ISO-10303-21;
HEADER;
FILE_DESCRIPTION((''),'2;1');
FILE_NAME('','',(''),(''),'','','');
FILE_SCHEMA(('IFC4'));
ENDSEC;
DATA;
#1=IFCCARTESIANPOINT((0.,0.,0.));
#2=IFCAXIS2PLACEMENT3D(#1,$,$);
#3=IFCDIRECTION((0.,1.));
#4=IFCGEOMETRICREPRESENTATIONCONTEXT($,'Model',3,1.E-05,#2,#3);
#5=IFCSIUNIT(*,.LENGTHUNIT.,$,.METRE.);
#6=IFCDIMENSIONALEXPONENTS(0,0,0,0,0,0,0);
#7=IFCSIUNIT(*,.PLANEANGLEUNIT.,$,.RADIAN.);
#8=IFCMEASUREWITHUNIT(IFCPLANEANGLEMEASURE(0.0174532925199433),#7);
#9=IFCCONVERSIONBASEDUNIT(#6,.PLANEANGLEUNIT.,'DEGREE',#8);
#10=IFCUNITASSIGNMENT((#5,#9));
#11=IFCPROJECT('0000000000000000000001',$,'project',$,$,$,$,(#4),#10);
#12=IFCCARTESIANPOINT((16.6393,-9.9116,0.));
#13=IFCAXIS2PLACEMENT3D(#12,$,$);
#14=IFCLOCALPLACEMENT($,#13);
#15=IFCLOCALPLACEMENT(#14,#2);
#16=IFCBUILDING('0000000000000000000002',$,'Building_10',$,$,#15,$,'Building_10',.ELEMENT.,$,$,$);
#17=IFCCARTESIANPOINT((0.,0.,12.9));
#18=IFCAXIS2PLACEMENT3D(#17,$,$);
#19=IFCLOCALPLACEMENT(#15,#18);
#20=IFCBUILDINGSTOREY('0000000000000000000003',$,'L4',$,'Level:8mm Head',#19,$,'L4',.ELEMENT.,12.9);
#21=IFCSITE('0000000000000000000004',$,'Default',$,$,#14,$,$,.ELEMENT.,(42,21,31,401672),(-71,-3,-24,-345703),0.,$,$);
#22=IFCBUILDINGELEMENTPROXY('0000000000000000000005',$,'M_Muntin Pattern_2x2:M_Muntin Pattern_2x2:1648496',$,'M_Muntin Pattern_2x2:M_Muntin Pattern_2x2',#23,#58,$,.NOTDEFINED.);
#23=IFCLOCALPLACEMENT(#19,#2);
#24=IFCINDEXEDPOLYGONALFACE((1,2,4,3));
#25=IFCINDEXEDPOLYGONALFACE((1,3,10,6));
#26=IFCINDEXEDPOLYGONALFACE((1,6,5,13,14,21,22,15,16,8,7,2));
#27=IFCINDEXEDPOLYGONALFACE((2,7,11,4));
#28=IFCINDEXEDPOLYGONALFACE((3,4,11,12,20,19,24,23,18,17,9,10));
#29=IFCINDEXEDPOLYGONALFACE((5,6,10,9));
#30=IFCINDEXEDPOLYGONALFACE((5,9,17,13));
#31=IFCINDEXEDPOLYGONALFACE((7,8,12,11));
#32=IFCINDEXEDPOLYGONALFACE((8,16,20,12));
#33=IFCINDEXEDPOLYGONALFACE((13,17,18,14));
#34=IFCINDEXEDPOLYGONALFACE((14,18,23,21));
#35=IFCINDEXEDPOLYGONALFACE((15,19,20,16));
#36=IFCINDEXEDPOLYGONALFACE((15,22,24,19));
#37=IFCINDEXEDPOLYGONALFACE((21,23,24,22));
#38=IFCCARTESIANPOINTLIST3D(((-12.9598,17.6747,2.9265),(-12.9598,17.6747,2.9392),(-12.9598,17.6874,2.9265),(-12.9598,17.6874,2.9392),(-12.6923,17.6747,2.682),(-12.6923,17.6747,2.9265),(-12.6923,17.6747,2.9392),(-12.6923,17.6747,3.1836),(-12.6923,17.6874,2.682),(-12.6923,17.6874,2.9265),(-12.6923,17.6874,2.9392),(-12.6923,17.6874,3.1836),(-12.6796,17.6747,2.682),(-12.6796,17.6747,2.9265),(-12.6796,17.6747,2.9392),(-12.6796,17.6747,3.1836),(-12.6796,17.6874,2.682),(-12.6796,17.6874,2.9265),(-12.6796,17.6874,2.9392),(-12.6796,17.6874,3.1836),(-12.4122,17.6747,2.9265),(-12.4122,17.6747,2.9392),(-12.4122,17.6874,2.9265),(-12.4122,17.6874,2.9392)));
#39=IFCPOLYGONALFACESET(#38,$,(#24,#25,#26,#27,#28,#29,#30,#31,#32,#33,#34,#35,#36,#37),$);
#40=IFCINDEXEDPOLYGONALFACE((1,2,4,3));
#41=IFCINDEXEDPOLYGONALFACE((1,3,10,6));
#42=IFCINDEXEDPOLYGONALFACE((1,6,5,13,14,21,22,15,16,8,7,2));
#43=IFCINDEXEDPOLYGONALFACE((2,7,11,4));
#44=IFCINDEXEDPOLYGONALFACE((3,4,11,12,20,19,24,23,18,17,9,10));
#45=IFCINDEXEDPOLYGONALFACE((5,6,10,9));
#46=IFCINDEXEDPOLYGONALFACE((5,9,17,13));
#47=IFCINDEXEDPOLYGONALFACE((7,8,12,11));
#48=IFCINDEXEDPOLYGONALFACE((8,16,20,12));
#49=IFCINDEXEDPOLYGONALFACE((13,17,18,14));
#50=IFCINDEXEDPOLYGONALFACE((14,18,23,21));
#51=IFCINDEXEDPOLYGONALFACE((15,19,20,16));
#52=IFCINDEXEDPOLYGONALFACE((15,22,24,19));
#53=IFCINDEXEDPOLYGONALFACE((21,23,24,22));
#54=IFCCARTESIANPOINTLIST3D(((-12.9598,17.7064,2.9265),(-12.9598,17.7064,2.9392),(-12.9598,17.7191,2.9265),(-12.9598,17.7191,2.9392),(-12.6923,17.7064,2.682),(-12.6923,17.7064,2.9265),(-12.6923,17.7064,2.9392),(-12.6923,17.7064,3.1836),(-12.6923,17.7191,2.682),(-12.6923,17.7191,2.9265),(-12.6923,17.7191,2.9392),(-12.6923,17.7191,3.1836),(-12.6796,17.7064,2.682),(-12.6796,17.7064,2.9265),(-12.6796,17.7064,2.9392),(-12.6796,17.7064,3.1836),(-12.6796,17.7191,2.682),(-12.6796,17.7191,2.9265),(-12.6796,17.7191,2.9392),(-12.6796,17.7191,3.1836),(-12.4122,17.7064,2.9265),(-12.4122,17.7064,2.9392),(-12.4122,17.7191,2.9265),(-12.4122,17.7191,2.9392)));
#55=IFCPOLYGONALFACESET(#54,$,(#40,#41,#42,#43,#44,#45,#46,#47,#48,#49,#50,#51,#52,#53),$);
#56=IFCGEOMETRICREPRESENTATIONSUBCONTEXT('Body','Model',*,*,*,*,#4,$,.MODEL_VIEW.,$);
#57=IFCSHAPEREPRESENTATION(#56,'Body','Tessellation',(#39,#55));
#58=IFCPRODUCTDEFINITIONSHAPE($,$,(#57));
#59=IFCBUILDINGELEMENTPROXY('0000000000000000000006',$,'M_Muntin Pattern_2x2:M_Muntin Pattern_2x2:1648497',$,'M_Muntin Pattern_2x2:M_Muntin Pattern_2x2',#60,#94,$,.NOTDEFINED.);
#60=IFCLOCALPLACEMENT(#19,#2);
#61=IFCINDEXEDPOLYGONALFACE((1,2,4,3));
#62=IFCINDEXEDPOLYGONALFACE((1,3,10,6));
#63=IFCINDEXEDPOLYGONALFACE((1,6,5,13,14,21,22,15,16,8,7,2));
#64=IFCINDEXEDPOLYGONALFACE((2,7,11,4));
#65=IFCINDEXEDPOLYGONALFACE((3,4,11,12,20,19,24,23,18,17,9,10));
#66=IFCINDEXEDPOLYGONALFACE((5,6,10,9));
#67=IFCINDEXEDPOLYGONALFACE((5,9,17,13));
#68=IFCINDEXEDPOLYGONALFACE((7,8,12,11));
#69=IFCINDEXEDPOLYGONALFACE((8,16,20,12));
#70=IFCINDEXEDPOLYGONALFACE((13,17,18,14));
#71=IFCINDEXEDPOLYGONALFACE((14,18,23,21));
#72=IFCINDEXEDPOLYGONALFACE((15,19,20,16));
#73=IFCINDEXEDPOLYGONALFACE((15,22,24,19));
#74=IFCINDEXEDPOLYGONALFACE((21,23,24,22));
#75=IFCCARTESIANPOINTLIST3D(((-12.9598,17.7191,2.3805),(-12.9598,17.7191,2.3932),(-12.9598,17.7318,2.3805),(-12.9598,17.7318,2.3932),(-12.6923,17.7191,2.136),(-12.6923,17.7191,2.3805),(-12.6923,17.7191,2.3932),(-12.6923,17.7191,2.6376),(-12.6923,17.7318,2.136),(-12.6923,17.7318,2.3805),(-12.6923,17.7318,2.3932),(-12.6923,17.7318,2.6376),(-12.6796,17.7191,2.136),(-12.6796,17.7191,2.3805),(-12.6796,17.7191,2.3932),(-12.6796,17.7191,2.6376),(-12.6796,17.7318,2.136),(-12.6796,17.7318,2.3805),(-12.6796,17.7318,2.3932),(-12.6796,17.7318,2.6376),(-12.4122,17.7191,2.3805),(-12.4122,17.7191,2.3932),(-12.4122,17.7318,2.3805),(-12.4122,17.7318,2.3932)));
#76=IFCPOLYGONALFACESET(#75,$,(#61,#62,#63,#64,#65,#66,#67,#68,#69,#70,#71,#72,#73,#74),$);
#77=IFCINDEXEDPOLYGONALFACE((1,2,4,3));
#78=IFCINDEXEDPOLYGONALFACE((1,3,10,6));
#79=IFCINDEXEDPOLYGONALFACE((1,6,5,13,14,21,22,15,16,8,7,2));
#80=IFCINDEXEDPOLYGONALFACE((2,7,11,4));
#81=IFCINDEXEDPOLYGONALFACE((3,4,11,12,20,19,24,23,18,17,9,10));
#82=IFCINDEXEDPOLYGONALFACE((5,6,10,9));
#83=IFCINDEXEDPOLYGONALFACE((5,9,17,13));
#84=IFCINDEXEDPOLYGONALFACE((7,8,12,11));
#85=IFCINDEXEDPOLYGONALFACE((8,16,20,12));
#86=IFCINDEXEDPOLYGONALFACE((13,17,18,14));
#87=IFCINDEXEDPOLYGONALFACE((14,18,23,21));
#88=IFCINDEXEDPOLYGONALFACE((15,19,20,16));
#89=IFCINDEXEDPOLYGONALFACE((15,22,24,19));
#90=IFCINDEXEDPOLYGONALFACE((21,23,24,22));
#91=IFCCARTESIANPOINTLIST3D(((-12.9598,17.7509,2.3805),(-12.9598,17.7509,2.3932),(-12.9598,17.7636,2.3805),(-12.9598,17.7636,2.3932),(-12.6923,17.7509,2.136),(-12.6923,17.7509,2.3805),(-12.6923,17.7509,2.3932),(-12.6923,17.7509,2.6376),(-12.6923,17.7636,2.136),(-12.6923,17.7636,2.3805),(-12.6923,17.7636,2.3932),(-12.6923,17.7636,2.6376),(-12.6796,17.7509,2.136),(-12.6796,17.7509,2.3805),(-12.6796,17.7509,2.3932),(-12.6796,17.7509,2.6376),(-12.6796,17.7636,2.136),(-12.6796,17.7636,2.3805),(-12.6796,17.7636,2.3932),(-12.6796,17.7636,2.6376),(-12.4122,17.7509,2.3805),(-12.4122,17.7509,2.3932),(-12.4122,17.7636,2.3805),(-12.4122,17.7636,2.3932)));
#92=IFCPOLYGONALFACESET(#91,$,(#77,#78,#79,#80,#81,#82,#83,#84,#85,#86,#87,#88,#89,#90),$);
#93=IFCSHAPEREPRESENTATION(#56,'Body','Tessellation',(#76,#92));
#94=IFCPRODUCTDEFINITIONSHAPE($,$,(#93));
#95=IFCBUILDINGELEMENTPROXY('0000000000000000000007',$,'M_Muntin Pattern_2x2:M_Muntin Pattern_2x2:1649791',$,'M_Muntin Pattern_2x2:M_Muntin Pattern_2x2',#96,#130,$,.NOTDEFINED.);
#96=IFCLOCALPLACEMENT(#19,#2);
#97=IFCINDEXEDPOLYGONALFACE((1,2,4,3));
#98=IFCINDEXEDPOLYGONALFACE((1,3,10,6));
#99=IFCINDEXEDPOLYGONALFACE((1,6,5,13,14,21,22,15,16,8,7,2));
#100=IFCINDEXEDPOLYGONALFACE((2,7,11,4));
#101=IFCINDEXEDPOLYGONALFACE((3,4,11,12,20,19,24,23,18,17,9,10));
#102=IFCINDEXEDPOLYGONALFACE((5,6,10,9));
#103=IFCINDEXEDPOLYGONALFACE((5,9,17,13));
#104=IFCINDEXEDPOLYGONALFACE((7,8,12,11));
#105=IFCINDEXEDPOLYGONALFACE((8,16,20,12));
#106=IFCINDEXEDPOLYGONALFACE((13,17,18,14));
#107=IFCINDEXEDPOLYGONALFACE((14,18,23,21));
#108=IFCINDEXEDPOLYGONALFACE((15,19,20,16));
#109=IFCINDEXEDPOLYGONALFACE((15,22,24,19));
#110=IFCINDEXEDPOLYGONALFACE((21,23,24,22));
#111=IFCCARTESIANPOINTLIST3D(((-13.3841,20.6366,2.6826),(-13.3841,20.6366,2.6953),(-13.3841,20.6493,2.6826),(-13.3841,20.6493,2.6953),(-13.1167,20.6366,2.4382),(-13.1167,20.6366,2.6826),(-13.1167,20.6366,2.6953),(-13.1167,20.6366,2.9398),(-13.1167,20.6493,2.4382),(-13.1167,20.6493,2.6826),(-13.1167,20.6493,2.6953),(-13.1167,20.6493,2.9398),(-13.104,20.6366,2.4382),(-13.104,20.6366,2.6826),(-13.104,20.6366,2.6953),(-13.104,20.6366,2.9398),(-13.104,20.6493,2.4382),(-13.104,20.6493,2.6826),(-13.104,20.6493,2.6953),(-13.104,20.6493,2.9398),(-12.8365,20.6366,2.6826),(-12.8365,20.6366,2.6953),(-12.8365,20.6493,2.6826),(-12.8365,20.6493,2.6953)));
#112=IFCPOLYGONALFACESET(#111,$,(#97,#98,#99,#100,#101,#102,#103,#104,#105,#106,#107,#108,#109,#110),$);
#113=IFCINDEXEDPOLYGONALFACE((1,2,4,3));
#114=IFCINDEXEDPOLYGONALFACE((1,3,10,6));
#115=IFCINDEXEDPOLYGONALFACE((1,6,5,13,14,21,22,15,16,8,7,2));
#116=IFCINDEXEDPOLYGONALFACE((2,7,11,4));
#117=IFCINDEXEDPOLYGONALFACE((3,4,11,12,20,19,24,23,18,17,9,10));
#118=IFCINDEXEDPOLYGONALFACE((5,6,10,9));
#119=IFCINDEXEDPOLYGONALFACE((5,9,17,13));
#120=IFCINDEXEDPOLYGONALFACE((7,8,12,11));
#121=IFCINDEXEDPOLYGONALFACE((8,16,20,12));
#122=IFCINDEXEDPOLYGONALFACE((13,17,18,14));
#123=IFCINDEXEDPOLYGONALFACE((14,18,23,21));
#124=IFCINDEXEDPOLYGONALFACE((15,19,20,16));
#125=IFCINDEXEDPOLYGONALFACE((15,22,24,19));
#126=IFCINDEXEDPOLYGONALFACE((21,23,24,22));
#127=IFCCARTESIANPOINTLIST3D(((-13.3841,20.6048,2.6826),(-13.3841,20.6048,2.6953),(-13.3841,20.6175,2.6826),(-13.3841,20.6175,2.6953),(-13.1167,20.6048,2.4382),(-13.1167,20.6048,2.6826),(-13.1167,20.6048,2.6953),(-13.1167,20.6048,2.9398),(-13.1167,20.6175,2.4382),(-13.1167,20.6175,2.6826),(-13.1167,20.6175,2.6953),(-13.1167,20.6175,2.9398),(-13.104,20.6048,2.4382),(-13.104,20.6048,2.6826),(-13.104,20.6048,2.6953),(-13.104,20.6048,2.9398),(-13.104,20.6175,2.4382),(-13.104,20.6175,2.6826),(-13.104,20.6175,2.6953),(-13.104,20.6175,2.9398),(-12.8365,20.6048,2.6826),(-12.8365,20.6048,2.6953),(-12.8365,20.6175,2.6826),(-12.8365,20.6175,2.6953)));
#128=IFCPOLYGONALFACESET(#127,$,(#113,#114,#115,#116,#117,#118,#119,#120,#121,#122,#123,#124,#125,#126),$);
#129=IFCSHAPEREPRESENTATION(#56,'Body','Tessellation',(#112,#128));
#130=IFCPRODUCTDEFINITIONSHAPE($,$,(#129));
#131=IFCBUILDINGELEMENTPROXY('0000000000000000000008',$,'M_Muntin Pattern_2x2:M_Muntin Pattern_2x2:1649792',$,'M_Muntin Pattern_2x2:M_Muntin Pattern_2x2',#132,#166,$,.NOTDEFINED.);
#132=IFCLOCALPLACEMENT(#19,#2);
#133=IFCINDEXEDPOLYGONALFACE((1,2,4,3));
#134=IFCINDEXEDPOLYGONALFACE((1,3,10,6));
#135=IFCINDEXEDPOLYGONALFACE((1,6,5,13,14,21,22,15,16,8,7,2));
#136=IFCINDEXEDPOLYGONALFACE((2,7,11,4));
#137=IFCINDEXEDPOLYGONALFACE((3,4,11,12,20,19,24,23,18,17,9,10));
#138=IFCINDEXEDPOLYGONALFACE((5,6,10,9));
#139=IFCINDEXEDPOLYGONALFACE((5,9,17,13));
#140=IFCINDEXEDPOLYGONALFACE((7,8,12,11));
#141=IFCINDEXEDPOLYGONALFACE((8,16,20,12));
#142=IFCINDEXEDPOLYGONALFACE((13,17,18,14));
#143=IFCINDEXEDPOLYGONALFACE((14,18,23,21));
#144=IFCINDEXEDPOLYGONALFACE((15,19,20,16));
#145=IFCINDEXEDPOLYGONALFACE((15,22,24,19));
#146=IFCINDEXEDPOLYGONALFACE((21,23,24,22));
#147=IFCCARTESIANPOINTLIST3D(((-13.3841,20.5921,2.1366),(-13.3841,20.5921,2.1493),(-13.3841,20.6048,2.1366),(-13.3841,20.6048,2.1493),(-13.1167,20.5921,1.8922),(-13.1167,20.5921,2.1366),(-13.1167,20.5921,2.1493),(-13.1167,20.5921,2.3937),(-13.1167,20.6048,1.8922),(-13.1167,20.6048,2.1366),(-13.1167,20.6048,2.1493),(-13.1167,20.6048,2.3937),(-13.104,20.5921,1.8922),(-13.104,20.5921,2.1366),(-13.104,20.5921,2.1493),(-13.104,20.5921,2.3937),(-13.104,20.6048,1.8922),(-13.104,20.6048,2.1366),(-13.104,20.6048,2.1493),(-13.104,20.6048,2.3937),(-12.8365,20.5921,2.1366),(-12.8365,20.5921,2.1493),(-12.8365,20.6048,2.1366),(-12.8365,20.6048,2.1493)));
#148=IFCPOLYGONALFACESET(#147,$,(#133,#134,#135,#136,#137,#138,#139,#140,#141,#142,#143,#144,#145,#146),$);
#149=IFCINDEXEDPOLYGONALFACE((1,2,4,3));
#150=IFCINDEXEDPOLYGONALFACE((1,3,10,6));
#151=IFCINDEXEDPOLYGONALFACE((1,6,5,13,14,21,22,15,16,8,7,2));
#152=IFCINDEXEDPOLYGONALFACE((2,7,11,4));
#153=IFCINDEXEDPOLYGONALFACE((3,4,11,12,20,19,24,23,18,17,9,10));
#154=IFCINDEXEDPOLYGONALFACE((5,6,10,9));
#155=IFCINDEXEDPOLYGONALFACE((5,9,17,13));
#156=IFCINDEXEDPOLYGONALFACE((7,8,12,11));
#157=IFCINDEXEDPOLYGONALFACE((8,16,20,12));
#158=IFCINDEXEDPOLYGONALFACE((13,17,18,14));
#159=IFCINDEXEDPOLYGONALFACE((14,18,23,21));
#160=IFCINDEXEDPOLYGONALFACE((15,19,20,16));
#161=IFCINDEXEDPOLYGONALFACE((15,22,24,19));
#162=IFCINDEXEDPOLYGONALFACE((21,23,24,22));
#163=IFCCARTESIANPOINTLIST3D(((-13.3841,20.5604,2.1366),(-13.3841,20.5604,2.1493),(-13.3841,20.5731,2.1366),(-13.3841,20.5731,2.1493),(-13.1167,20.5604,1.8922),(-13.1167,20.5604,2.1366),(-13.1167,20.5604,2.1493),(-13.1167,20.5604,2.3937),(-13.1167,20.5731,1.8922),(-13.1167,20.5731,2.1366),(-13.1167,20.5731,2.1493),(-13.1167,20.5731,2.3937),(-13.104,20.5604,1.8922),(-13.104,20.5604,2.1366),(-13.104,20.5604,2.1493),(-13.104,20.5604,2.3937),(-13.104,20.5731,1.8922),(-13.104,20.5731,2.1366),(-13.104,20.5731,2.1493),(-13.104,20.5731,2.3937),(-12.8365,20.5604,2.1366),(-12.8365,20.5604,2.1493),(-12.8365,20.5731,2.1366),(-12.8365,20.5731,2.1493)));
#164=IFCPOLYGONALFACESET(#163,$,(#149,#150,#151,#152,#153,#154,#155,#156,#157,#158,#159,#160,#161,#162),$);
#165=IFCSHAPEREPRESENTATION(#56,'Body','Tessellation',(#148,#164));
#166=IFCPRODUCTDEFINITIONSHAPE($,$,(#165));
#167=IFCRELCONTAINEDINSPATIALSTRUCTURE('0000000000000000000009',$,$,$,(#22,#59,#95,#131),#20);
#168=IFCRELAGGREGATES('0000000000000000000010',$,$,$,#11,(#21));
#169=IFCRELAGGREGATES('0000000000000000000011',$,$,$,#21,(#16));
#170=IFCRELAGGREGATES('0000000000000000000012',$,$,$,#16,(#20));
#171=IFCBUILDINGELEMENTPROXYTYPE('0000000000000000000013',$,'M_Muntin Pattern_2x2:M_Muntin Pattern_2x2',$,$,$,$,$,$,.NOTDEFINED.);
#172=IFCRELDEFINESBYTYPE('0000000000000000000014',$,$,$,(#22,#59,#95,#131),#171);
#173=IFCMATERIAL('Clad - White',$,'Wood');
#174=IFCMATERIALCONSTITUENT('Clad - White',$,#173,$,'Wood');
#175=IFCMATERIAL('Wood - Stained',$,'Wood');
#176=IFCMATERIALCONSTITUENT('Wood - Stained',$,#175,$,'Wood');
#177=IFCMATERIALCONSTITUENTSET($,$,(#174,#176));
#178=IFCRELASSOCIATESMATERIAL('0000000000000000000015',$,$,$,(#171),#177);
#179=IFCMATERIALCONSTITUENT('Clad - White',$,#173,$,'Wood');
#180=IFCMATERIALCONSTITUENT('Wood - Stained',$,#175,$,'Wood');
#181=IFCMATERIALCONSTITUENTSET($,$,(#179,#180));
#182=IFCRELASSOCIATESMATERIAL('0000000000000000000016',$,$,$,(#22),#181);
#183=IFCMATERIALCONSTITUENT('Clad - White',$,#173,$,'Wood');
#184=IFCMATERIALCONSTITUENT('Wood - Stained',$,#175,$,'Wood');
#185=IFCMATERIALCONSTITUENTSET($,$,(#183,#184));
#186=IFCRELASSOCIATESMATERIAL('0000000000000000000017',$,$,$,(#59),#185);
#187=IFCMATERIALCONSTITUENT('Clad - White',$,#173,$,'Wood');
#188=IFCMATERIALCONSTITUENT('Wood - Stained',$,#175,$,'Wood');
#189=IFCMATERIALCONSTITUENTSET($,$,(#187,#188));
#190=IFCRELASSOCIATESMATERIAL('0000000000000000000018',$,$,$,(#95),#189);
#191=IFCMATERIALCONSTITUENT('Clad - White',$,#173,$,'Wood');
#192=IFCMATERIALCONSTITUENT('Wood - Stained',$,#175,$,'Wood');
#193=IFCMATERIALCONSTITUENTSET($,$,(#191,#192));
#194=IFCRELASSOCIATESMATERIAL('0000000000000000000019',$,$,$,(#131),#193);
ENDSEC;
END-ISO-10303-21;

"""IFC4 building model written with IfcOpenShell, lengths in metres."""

from ifc_helpers import new_model, entity, si_unit, converted_unit, direction, frame, origin, place, context, subcontext, project, spatial, indexed_curve, outline, extrude, source, transform, mapped, material, constituent, constituent_set, type_object, type_shapes, element, save


model = new_model("IFC4")

# Units and contexts
model_context = context("Model", 3, precision=1e-05, world=origin(), true_north=direction((0.0, 1.0)))
body_context = subcontext(model_context, "Body", "Model", "MODEL_VIEW")
ifc_project = project(units=[si_unit("LENGTHUNIT", "METRE"), converted_unit("PLANEANGLEUNIT", "DEGREE", entity("IfcPlaneAngleMeasure", 0.0174532925199433), si_unit("PLANEANGLEUNIT", "RADIAN"), dimensions=[0, 0, 0, 0, 0, 0, 0])], contexts=[model_context])

# Site, building, storey
site_placement = place(None, frame((16.6393, -9.9116, 0.0)))
site = spatial("IfcSite", under=ifc_project, at=site_placement, Name="Default", CompositionType="ELEMENT", RefLatitude=(42, 21, 31, 401672), RefLongitude=(-71, -3, -24, -345703), RefElevation=0.0)
building_placement = place(site_placement, origin())
building = spatial("IfcBuilding", under=site, at=building_placement, Name="Building_10", LongName="Building_10", CompositionType="ELEMENT")
storey_placement = place(building_placement, frame((0.0, 0.0, 12.9)))
storey = spatial("IfcBuildingStorey", under=building, at=storey_placement, Name="L4", ObjectType="Level:8mm Head", LongName="L4", CompositionType="ELEMENT", Elevation=12.9)

# Building element proxies
ifc_material_1 = material(Name="Clad - White", Category="Wood")
ifc_material_2 = material(Name="Wood - Stained", Category="Wood")
ifc_constituent_1 = constituent(ifc_material_1, Name="Clad - White", Category="Wood")
ifc_constituent_2 = constituent(ifc_material_2, Name="Wood - Stained", Category="Wood")
ifc_constituent_set_1 = constituent_set(constituents=[ifc_constituent_1, ifc_constituent_2])
ifc_constituent_3 = constituent(ifc_material_1, Name="Clad - White", Category="Wood")
ifc_constituent_4 = constituent(ifc_material_2, Name="Wood - Stained", Category="Wood")
ifc_constituent_set_2 = constituent_set(constituents=[ifc_constituent_3, ifc_constituent_4])
building_element_proxy_type_1 = type_object("IfcBuildingElementProxyType", Name="M_Muntin Pattern_2x2:M_Muntin Pattern_2x2", PredefinedType="NOTDEFINED", material=ifc_constituent_set_2)
shared_shape_1 = source(origin(), body_context, "Body", "SweptSolid", [
    extrude(outline(indexed_curve([(0.0064, -0.0064), (0.2508, -0.0064), (0.2508, 0.0063), (0.0064, 0.0063), (0.0064, 0.2738), (-0.0063, 0.2738), (-0.0063, 0.0063), (-0.2508, 0.0063), (-0.2508, -0.0064), (-0.0063, -0.0064), (-0.0063, -0.2738), (0.0064, -0.2738), (0.0064, -0.0064)], self_intersect=False)), frame((0.0, 0.0095, 0.2508), z_axis=(0.0, 1.0, 0.0), x_axis=(0.0, 0.0, 1.0)), (0.0, 0.0, 1.0), 0.0127),
    extrude(outline(indexed_curve([(0.0064, -0.0064), (0.2508, -0.0064), (0.2508, 0.0063), (0.0064, 0.0063), (0.0064, 0.2738), (-0.0063, 0.2738), (-0.0063, 0.0063), (-0.2508, 0.0063), (-0.2508, -0.0064), (-0.0063, -0.0064), (-0.0063, -0.2738), (0.0064, -0.2738), (0.0064, -0.0064)], self_intersect=False)), frame((0.0, -0.0222, 0.2508), z_axis=(0.0, 1.0, 0.0), x_axis=(0.0, 0.0, 1.0)), (0.0, 0.0, 1.0), 0.0127),
])
type_shapes(building_element_proxy_type_1, [shared_shape_1])
proxy_1_placement = place(storey_placement, frame((-12.686, 17.6969, 2.682), z_axis=(0.0, 0.0, 1.0), x_axis=(-1.0, 0.0, 0.0)))
element("IfcBuildingElementProxy", 1, at=proxy_1_placement, inside=storey, type_object=building_element_proxy_type_1, material=ifc_constituent_set_1, Name="M_Muntin Pattern_2x2:M_Muntin Pattern_2x2:1648496", ObjectType="M_Muntin Pattern_2x2:M_Muntin Pattern_2x2", PredefinedType="NOTDEFINED", context=body_context, shape_type="MappedRepresentation", body=[
    mapped(shared_shape_1, transform((0.0, 0.0, 0.0), scale=1.0)),
])
ifc_constituent_5 = constituent(ifc_material_1, Name="Clad - White", Category="Wood")
ifc_constituent_6 = constituent(ifc_material_2, Name="Wood - Stained", Category="Wood")
ifc_constituent_set_3 = constituent_set(constituents=[ifc_constituent_5, ifc_constituent_6])
proxy_2_placement = place(storey_placement, frame((-12.686, 17.7413, 2.136), z_axis=(0.0, 0.0, 1.0), x_axis=(-1.0, 0.0, 0.0)))
element("IfcBuildingElementProxy", 2, at=proxy_2_placement, inside=storey, type_object=building_element_proxy_type_1, material=ifc_constituent_set_3, Name="M_Muntin Pattern_2x2:M_Muntin Pattern_2x2:1648497", ObjectType="M_Muntin Pattern_2x2:M_Muntin Pattern_2x2", PredefinedType="NOTDEFINED", context=body_context, shape_type="MappedRepresentation", body=[
    mapped(shared_shape_1, transform((0.0, 0.0, 0.0), scale=1.0)),
])
ifc_constituent_7 = constituent(ifc_material_1, Name="Clad - White", Category="Wood")
ifc_constituent_8 = constituent(ifc_material_2, Name="Wood - Stained", Category="Wood")
ifc_constituent_set_4 = constituent_set(constituents=[ifc_constituent_7, ifc_constituent_8])
proxy_3_placement = place(storey_placement, frame((-13.1103, 20.627, 2.4382)))
element("IfcBuildingElementProxy", 3, at=proxy_3_placement, inside=storey, type_object=building_element_proxy_type_1, material=ifc_constituent_set_4, Name="M_Muntin Pattern_2x2:M_Muntin Pattern_2x2:1649791", ObjectType="M_Muntin Pattern_2x2:M_Muntin Pattern_2x2", PredefinedType="NOTDEFINED", context=body_context, shape_type="MappedRepresentation", body=[
    mapped(shared_shape_1, transform((0.0, 0.0, 0.0), scale=1.0)),
])
ifc_constituent_9 = constituent(ifc_material_1, Name="Clad - White", Category="Wood")
ifc_constituent_10 = constituent(ifc_material_2, Name="Wood - Stained", Category="Wood")
ifc_constituent_set_5 = constituent_set(constituents=[ifc_constituent_9, ifc_constituent_10])
proxy_4_placement = place(storey_placement, frame((-13.1103, 20.5826, 1.8922)))
element("IfcBuildingElementProxy", 4, at=proxy_4_placement, inside=storey, type_object=building_element_proxy_type_1, material=ifc_constituent_set_5, Name="M_Muntin Pattern_2x2:M_Muntin Pattern_2x2:1649792", ObjectType="M_Muntin Pattern_2x2:M_Muntin Pattern_2x2", PredefinedType="NOTDEFINED", context=body_context, shape_type="MappedRepresentation", body=[
    mapped(shared_shape_1, transform((0.0, 0.0, 0.0), scale=1.0)),
])

save(model, "model.ifc")
